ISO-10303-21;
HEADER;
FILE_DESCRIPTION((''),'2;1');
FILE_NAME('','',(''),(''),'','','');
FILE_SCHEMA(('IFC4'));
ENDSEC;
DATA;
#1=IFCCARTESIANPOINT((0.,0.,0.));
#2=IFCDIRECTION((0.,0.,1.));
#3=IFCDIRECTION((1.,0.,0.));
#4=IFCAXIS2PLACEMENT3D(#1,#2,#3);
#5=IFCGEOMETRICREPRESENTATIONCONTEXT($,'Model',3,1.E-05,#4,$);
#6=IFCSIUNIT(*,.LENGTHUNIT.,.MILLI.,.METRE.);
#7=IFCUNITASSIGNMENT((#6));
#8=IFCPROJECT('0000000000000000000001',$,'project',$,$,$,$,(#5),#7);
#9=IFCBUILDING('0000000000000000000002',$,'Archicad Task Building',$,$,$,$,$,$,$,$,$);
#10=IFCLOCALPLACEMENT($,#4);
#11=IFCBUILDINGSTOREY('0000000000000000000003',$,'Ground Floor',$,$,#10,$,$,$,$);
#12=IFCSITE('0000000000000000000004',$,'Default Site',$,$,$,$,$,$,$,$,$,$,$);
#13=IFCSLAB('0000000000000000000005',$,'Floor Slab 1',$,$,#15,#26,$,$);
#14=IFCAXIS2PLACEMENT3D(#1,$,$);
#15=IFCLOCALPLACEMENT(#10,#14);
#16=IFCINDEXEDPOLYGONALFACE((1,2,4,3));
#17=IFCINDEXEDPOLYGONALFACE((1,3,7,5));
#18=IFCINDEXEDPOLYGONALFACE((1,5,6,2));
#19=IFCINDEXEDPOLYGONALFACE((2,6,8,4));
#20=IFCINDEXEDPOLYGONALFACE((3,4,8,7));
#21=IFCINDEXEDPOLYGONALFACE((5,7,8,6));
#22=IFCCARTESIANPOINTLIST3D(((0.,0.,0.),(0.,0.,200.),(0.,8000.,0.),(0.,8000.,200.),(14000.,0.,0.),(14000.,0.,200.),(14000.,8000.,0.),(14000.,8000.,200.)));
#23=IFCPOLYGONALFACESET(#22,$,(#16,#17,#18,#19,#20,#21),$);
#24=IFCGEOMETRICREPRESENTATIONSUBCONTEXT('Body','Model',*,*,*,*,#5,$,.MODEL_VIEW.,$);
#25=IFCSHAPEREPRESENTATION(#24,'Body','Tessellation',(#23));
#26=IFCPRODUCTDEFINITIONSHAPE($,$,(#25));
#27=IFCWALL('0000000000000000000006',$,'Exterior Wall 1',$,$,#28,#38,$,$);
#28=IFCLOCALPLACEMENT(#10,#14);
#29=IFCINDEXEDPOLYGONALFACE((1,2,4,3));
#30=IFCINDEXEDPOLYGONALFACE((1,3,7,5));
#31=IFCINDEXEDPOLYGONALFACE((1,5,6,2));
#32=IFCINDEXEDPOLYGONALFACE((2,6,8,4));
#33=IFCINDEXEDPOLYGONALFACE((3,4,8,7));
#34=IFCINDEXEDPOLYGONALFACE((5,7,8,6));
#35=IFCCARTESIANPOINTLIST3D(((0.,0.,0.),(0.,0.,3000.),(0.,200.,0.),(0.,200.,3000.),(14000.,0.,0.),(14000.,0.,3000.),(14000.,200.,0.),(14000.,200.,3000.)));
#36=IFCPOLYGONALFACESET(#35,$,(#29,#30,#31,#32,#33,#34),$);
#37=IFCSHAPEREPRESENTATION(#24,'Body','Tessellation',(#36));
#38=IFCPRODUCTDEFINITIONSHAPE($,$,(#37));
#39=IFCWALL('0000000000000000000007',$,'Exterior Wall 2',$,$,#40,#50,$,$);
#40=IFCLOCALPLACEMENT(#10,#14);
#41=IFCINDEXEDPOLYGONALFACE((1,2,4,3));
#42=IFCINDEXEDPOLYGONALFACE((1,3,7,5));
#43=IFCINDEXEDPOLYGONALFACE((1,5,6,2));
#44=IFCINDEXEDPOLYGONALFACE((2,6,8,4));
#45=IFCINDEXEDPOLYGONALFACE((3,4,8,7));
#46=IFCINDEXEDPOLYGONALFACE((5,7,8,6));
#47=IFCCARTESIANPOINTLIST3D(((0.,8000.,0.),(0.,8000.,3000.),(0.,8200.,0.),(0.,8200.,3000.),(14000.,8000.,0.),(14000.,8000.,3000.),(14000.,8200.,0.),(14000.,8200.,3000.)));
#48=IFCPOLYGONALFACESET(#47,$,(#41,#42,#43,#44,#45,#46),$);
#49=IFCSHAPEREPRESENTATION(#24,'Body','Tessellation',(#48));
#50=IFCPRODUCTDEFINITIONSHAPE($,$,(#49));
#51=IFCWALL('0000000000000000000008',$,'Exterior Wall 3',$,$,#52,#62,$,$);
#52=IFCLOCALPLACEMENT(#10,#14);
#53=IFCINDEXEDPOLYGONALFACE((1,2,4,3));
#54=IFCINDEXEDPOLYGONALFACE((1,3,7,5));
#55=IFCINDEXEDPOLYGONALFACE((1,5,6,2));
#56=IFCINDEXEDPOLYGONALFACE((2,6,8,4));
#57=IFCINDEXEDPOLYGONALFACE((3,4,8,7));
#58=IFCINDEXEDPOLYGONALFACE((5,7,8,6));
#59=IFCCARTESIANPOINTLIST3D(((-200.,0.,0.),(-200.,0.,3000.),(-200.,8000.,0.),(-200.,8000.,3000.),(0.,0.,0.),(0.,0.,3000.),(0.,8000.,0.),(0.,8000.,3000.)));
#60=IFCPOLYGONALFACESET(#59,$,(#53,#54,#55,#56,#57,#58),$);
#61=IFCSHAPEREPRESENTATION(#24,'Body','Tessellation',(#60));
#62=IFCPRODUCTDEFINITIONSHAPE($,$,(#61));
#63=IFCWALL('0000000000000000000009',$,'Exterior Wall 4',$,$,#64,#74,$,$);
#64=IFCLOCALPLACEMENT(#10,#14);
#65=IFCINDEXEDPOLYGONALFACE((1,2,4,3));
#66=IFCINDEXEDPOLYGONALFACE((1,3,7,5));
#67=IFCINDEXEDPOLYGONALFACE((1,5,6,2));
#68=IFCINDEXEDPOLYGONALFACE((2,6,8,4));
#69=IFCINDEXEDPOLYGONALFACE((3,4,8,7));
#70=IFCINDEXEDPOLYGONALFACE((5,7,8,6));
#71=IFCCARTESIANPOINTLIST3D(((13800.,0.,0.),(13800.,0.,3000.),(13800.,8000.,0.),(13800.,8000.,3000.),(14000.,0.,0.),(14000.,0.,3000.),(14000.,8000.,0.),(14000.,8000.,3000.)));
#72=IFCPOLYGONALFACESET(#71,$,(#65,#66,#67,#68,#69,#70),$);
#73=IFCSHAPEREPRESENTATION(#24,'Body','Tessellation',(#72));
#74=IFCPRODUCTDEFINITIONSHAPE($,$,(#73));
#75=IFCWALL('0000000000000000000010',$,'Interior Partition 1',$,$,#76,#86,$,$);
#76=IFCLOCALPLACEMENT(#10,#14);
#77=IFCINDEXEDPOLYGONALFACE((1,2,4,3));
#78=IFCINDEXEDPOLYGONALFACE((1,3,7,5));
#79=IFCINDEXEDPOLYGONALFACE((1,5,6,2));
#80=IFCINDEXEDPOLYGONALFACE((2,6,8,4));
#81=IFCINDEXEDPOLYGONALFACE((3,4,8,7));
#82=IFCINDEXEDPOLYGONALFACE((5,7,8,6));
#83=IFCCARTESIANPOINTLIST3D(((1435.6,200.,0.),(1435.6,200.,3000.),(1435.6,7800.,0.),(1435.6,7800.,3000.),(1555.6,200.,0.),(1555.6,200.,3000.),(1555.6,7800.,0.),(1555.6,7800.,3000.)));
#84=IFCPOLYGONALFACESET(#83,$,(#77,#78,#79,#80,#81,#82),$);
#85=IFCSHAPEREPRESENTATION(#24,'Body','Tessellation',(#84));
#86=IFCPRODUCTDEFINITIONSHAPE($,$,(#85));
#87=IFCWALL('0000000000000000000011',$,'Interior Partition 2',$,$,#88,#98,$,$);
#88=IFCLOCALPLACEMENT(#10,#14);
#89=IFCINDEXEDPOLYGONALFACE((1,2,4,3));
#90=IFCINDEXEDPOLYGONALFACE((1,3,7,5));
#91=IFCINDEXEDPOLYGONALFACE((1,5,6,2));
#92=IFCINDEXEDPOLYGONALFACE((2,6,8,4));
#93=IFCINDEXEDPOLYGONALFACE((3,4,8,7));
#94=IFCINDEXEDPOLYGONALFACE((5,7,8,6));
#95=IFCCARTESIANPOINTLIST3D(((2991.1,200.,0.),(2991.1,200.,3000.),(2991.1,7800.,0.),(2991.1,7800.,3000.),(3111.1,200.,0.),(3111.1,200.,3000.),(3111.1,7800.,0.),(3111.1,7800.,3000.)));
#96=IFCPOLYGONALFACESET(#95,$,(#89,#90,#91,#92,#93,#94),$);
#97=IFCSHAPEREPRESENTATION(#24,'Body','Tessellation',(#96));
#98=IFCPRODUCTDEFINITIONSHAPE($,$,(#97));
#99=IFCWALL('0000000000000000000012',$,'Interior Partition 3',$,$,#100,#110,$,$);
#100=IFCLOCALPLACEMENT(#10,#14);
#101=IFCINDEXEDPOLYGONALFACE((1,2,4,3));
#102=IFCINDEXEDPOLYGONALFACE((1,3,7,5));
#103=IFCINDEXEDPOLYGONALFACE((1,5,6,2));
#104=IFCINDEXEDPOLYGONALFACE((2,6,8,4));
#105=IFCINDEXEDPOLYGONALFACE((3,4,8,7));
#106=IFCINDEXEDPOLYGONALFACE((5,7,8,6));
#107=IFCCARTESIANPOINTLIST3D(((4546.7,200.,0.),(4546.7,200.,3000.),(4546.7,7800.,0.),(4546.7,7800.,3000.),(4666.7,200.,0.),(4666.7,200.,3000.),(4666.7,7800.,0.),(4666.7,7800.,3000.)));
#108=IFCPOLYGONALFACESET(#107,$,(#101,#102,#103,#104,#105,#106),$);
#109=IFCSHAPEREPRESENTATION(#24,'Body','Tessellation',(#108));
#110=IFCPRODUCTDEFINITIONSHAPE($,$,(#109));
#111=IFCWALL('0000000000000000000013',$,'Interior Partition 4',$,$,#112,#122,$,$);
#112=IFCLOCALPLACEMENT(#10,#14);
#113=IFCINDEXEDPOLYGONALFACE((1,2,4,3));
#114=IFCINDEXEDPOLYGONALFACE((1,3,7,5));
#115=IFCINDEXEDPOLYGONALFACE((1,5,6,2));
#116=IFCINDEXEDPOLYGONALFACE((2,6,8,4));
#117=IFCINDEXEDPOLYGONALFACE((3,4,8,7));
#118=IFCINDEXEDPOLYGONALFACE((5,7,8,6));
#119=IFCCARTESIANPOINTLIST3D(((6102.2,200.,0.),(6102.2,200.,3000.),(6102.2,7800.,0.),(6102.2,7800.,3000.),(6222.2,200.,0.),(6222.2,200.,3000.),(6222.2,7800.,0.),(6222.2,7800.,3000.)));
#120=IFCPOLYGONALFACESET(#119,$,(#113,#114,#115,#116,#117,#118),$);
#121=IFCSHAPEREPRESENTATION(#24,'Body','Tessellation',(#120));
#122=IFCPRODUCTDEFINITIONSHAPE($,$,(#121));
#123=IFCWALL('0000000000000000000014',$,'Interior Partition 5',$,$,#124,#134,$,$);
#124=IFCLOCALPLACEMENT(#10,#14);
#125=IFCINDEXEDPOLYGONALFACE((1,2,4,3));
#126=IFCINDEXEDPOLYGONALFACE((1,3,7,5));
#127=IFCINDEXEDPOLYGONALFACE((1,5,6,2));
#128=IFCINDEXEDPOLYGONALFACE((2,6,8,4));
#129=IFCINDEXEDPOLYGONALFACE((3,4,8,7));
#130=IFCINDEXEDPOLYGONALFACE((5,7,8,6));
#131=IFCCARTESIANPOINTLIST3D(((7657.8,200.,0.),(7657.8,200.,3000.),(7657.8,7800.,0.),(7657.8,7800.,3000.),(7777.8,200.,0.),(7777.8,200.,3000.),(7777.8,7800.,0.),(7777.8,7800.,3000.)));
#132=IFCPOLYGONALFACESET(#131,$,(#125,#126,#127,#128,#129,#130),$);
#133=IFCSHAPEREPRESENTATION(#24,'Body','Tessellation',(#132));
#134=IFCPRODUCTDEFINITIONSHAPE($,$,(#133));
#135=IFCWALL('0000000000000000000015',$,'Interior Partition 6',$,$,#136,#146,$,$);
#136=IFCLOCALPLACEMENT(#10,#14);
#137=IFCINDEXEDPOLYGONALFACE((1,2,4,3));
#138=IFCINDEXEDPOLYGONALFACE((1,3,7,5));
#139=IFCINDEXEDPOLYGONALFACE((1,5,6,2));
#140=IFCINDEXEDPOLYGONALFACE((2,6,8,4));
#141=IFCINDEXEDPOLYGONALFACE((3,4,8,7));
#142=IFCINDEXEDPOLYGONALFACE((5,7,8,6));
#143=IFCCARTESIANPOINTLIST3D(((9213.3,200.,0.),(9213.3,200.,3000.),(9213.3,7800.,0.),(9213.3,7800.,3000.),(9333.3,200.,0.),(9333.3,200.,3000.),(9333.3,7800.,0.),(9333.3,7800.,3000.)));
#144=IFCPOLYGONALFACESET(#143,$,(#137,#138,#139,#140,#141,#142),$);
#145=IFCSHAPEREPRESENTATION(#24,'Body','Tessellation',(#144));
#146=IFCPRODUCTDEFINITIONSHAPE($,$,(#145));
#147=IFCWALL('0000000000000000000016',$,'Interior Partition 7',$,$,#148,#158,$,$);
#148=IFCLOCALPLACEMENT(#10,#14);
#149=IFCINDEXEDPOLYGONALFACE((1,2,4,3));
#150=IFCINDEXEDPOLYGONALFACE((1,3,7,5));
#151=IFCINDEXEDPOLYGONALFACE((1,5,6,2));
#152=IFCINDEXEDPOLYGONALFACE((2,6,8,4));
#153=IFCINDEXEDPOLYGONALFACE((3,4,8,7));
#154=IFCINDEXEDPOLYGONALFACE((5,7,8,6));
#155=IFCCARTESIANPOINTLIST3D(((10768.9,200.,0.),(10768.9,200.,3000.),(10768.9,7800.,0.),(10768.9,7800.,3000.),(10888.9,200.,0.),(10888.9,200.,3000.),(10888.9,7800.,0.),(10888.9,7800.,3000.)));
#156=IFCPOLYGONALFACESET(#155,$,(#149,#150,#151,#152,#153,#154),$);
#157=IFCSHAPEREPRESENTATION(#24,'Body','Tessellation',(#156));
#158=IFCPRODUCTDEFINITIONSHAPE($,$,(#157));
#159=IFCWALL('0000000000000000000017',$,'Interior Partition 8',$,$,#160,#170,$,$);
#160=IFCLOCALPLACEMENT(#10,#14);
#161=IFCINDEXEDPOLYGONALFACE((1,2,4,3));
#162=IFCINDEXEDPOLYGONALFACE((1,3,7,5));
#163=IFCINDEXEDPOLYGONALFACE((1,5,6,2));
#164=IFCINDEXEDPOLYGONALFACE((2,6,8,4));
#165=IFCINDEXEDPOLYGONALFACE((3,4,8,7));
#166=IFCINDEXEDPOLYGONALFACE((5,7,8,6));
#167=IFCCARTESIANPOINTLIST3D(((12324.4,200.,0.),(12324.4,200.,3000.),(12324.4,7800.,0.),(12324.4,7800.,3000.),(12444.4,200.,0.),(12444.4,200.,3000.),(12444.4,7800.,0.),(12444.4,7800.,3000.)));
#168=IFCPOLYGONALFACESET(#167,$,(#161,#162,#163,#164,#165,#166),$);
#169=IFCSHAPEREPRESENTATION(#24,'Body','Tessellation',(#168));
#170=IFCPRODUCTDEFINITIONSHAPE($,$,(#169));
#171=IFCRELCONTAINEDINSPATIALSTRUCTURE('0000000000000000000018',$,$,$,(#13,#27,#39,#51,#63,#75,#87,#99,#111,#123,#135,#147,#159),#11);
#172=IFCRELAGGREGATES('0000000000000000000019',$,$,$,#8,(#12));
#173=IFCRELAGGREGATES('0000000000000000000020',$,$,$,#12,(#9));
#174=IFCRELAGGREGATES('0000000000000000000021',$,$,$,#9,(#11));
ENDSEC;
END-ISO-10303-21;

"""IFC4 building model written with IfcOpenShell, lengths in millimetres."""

from ifc_helpers import new_model, si_unit, frame, origin_with_axes, place, context, subcontext, project, spatial, indexed_curve, outline, extrude, element, save


model = new_model("IFC4")

# Units and contexts
model_context = context("Model", 3, precision=1e-05, world=origin_with_axes())
body_context = subcontext(model_context, "Body", "Model", "MODEL_VIEW")
ifc_project = project(units=[si_unit("LENGTHUNIT", "METRE", prefix="MILLI")], contexts=[model_context])

# Site, building, storey
site = spatial("IfcSite", under=ifc_project, Name="Default Site")
building = spatial("IfcBuilding", under=site, Name="Archicad Task Building")
storey_placement = place(None, origin_with_axes())
storey = spatial("IfcBuildingStorey", under=building, at=storey_placement, Name="Ground Floor")

# Slab
slab_placement = place(storey_placement, origin_with_axes())
element("IfcSlab", 1, at=slab_placement, inside=storey, Name="Floor Slab 1", context=body_context, shape_type="SweptSolid", body=[
    extrude(outline(indexed_curve([(0.0, 0.0), (14000.0, 0.0), (14000.0, 8000.0), (0.0, 8000.0), (0.0, 0.0)])), None, (0.0, 0.0, 1.0), 200.0),
])

# Walls
for number, where, z_axis, x_axis, name in (
    (2, (0.0, 0.0, 0.0), (0.0, 0.0, 1.0), (1.0, 0.0, 0.0), "Exterior Wall 1"),
    (3, (0.0, 8000.0, 0.0), (0.0, 0.0, 1.0), (1.0, 0.0, 0.0), "Exterior Wall 2"),
):
    element("IfcWall", number, at=place(storey_placement, frame(where, z_axis=z_axis, x_axis=x_axis)), inside=storey, Name=name, context=body_context, shape_type="SweptSolid", body=[
        extrude(outline(indexed_curve([(0.0, 0.0), (0.0, 200.0), (14000.0, 200.0), (14000.0, 0.0), (0.0, 0.0)], self_intersect=False)), origin_with_axes(), (0.0, 0.0, 1.0), 3000.0),
    ])
for number, where, z_axis, x_axis, name in (
    (4, (0.0, 0.0, 0.0), (0.0, 0.0, 1.0), (0.0, 1.0, 0.0), "Exterior Wall 3"),
    (5, (14000.0, 0.0, 0.0), (0.0, 0.0, 1.0), (0.0, 1.0, 0.0), "Exterior Wall 4"),
):
    element("IfcWall", number, at=place(storey_placement, frame(where, z_axis=z_axis, x_axis=x_axis)), inside=storey, Name=name, context=body_context, shape_type="SweptSolid", body=[
        extrude(outline(indexed_curve([(0.0, 0.0), (0.0, 200.0), (8000.0, 200.0), (8000.0, 0.0), (0.0, 0.0)], self_intersect=False)), origin_with_axes(), (0.0, 0.0, 1.0), 3000.0),
    ])
for number, where, z_axis, x_axis, name in (
    (6, (1555.6, 200.0, 0.0), (0.0, 0.0, 1.0), (0.0, 1.0, 0.0), "Interior Partition 1"),
    (7, (3111.1, 200.0, 0.0), (0.0, 0.0, 1.0), (0.0, 1.0, 0.0), "Interior Partition 2"),
    (8, (4666.7, 200.0, 0.0), (0.0, 0.0, 1.0), (0.0, 1.0, 0.0), "Interior Partition 3"),
    (9, (6222.2, 200.0, 0.0), (0.0, 0.0, 1.0), (0.0, 1.0, 0.0), "Interior Partition 4"),
    (10, (7777.8, 200.0, 0.0), (0.0, 0.0, 1.0), (0.0, 1.0, 0.0), "Interior Partition 5"),
    (11, (9333.3, 200.0, 0.0), (0.0, 0.0, 1.0), (0.0, 1.0, 0.0), "Interior Partition 6"),
    (12, (10888.9, 200.0, 0.0), (0.0, 0.0, 1.0), (0.0, 1.0, 0.0), "Interior Partition 7"),
    (13, (12444.4, 200.0, 0.0), (0.0, 0.0, 1.0), (0.0, 1.0, 0.0), "Interior Partition 8"),
):
    element("IfcWall", number, at=place(storey_placement, frame(where, z_axis=z_axis, x_axis=x_axis)), inside=storey, Name=name, context=body_context, shape_type="SweptSolid", body=[
        extrude(outline(indexed_curve([(0.0, 0.0), (0.0, 120.0), (7600.0, 120.0), (7600.0, 0.0), (0.0, 0.0)], self_intersect=False)), origin_with_axes(), (0.0, 0.0, 1.0), 3000.0),
    ])

save(model, "model.ifc")
